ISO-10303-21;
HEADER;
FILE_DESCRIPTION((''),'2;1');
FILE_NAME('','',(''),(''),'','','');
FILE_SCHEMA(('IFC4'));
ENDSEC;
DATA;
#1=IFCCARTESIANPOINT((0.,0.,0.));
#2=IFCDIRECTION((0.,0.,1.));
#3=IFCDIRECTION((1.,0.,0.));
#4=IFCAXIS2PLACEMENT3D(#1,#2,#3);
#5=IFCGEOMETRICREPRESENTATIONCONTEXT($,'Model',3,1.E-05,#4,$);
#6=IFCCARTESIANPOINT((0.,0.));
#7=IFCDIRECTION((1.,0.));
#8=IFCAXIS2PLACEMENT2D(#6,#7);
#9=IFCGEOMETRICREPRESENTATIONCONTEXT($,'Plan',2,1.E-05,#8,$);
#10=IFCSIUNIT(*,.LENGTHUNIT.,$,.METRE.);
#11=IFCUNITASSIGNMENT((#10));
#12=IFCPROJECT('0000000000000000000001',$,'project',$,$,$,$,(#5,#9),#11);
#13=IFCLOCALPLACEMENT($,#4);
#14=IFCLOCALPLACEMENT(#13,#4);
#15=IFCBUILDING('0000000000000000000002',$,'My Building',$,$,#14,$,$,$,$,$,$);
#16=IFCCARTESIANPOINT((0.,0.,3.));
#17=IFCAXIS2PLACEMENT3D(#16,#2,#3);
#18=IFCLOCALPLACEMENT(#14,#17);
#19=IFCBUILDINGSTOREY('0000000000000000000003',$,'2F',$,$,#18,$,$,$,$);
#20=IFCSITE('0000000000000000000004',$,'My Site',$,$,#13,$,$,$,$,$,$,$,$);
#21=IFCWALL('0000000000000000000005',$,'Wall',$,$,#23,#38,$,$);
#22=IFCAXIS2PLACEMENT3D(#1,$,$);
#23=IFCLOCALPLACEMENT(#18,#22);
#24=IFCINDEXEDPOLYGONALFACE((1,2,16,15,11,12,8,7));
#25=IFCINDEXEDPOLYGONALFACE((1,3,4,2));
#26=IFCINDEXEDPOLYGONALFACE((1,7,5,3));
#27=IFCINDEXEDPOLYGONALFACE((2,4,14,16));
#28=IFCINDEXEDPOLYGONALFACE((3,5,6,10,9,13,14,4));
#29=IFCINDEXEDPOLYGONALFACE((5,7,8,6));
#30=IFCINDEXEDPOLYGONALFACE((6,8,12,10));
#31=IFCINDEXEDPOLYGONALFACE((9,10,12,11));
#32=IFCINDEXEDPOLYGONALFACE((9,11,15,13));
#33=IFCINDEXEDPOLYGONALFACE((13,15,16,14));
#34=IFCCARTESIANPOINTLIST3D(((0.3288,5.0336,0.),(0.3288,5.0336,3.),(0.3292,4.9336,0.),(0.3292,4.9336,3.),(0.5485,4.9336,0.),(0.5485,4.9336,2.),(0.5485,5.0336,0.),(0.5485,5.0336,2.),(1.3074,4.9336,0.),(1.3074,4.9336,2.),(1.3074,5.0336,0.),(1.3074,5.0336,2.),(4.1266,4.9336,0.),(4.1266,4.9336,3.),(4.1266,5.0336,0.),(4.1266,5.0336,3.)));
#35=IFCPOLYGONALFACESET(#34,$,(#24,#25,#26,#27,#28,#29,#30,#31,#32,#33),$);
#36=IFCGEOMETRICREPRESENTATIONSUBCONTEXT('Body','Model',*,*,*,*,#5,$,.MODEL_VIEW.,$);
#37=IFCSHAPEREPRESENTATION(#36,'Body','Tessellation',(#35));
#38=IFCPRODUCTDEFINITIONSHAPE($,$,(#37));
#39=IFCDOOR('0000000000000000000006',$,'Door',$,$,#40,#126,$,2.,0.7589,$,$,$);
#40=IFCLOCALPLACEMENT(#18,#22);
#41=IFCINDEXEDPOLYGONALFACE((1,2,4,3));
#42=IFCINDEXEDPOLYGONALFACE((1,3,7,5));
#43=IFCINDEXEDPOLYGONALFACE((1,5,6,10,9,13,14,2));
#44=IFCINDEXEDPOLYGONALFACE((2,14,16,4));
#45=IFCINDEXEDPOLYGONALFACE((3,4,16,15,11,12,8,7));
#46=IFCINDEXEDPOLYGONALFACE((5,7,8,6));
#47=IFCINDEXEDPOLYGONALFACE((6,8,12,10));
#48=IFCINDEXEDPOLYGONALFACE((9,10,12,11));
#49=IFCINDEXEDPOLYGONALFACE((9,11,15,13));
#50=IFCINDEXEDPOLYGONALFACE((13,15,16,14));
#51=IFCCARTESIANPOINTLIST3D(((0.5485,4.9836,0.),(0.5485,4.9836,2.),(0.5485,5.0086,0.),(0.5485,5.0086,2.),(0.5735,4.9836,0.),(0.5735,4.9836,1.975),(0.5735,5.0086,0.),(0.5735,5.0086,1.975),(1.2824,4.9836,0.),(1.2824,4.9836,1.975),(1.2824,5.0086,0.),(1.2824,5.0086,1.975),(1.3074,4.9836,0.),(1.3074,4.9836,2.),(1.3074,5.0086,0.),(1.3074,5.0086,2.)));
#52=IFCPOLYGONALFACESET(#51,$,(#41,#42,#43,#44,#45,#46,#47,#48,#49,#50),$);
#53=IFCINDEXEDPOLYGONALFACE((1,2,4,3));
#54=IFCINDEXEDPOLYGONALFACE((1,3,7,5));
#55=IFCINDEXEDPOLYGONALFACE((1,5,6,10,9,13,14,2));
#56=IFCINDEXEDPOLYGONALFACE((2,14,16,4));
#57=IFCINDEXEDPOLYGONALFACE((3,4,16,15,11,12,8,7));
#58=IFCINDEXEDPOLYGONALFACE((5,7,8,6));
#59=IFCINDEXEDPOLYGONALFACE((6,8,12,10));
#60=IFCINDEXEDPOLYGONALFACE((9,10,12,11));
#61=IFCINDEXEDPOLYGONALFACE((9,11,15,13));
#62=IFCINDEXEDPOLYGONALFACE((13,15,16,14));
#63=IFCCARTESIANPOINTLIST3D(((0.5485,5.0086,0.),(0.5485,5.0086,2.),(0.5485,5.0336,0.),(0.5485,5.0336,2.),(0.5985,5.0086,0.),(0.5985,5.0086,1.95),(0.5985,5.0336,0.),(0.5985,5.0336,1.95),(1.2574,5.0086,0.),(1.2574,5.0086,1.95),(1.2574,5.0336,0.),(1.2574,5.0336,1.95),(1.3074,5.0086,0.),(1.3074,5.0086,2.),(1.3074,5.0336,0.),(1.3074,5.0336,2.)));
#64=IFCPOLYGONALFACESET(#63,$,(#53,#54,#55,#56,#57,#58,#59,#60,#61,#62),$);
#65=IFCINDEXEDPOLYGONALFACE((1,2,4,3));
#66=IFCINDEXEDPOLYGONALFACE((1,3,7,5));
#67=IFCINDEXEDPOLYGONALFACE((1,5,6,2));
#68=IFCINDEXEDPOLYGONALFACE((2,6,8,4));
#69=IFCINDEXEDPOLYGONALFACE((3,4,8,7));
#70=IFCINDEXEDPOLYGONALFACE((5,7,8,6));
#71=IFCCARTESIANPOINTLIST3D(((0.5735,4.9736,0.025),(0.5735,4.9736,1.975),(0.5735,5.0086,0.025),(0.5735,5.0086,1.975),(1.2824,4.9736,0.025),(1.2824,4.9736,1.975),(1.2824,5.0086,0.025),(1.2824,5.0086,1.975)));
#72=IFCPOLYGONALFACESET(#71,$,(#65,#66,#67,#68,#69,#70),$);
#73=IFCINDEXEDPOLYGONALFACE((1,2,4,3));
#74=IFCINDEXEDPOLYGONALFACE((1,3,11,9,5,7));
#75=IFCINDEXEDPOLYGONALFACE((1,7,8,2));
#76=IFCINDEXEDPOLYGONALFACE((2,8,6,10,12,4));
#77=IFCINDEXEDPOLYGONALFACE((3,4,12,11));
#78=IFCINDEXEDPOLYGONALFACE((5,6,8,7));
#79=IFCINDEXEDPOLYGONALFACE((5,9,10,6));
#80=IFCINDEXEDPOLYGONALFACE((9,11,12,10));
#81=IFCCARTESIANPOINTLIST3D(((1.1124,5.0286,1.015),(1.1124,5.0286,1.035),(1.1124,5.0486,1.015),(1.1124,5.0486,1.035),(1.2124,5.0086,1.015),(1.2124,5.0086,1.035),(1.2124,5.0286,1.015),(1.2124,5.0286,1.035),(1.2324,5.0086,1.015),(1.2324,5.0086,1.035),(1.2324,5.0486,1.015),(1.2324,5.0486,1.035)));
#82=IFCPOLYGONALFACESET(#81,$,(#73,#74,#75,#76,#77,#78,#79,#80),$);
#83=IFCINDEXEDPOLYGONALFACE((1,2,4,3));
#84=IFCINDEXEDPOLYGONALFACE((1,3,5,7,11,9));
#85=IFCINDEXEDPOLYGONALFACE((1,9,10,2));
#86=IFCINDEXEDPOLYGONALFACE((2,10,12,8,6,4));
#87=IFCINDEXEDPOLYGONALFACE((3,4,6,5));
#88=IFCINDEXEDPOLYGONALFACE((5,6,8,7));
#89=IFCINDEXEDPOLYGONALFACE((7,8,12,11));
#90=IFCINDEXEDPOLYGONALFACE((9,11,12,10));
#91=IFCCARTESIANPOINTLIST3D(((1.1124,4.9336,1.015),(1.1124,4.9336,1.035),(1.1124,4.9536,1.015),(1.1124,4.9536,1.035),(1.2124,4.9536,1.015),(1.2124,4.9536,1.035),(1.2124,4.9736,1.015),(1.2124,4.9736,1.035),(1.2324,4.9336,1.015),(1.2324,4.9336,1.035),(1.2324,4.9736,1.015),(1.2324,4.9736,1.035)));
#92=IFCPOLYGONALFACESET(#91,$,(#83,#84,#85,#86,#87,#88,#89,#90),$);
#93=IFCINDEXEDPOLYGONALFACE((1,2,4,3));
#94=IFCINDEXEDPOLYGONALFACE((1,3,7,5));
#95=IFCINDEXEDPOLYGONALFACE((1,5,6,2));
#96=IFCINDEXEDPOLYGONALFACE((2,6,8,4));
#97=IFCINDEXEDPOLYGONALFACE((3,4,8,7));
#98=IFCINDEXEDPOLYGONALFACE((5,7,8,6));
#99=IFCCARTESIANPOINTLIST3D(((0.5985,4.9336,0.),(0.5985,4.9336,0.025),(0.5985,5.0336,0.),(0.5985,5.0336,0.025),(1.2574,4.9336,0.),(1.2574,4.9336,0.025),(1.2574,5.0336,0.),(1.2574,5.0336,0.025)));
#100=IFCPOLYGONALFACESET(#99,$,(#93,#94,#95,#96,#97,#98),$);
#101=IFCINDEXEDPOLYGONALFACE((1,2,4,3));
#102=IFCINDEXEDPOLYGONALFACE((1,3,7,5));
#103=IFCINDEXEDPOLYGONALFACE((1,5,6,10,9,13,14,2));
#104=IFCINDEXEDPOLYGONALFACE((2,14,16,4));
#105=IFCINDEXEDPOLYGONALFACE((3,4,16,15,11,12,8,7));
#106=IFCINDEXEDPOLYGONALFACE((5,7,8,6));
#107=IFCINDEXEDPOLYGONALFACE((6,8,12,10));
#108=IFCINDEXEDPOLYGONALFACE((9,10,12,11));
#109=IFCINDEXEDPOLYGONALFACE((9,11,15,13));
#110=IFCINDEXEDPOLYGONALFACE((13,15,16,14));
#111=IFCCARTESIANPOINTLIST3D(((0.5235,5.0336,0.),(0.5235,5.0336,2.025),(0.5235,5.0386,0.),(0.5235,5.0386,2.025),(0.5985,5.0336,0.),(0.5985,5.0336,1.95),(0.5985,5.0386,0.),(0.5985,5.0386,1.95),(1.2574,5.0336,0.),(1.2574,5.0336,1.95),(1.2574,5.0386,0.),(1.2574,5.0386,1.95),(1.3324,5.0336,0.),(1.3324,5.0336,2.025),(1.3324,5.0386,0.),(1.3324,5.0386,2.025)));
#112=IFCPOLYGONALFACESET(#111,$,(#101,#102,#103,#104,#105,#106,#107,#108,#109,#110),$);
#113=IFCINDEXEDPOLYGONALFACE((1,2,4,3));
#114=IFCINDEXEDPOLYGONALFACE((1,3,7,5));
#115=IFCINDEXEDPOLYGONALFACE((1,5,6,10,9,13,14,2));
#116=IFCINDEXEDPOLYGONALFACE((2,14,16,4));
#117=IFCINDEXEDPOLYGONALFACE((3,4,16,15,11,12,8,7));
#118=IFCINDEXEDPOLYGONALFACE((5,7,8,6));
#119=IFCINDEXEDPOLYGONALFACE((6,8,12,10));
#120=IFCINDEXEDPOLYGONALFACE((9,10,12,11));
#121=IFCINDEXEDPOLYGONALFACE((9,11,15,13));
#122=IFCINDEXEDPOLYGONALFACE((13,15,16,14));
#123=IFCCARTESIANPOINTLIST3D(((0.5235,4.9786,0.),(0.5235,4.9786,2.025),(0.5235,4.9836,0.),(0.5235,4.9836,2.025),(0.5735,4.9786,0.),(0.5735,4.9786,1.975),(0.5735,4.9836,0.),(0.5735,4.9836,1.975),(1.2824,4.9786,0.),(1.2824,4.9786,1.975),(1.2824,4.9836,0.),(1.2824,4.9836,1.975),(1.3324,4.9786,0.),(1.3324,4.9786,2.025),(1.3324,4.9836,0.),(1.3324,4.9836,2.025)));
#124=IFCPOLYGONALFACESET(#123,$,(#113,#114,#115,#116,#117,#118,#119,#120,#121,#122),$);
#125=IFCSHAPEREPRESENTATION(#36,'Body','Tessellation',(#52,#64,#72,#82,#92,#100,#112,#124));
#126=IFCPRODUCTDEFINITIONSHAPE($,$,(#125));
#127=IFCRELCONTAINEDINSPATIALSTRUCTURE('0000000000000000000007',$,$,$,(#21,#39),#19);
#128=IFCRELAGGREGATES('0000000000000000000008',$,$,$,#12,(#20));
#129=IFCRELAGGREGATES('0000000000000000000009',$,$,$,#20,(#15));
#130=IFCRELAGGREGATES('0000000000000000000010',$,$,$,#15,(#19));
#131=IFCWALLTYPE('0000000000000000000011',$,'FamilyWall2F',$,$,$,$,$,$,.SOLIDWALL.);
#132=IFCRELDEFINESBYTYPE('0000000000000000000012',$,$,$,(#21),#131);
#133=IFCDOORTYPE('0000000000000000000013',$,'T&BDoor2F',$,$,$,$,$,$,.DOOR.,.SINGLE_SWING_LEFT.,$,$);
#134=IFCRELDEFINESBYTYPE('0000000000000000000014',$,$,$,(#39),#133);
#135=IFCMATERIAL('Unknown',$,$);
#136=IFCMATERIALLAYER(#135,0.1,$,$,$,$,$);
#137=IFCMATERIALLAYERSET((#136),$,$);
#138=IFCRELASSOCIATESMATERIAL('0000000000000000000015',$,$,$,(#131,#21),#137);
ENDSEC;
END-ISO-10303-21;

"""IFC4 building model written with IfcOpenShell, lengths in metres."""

from ifc_helpers import new_model, entity, si_unit, frame, origin_with_axes, origin_2d_with_axis, place, context, subcontext, project, spatial, line, indexed_curve, outline, extrude, shape, source, transform, mapped, material, layer, layer_set, layer_usage, type_object, type_shapes, element, fill, save


model = new_model("IFC4")

# Units and contexts
model_context = context("Model", 3, precision=1e-05, world=origin_with_axes())
plan_context = context("Plan", 2, precision=1e-05, world=origin_2d_with_axis())
body_context_1 = subcontext(model_context, "Body", "Model", "MODEL_VIEW")
body_context_2 = subcontext(plan_context, "Body", "Plan", "PLAN_VIEW")
ifc_project = project(units=[si_unit("LENGTHUNIT", "METRE")], contexts=[model_context, plan_context])

# Site, building, storey
site_placement = place(None, origin_with_axes())
site = spatial("IfcSite", under=ifc_project, at=site_placement, Name="My Site")
building_placement = place(site_placement, origin_with_axes())
building = spatial("IfcBuilding", under=site, at=building_placement, Name="My Building")
storey_placement = place(building_placement, frame((0.0, 0.0, 3.0), z_axis=(0.0, 0.0, 1.0), x_axis=(1.0, 0.0, 0.0)))
storey = spatial("IfcBuildingStorey", under=building, at=storey_placement, Name="2F")

# Shared definitions
ifc_material = material(Name="Unknown")

# Wall, opening, door
ifc_layer_1 = layer(ifc_material, 0.1)
ifc_layer_set_1 = layer_set([ifc_layer_1])
ifc_layer_usage_1 = layer_usage(ifc_layer_set_1, "AXIS2", "POSITIVE", 0.0)
wall_type_1 = type_object("IfcWallType", Name="FamilyWall2F", PredefinedType="SOLIDWALL", material=ifc_layer_set_1)
wall_1_placement = place(storey_placement, frame((4.2266, 5.0336, 0.0), z_axis=(0.0, 0.0, 1.0), x_axis=(-1.0, 0.0, 0.0)))
wall_1 = element("IfcWall", 1, at=wall_1_placement, inside=storey, type_object=wall_type_1, material=ifc_layer_usage_1, Name="Wall", context=body_context_1, shape_type="SweptSolid", body=[
    extrude(outline(indexed_curve([(0.1, 0.0), (0.1, 0.1), (3.8974, 0.1), (3.8978, 0.0)], segments=[line(1, 2, 3, 4, 1)])), origin_with_axes(), (0.0, 0.0, 1.0), 3.0),
])
shared_shape_1 = source(origin_with_axes(), body_context_1, "Body", "SweptSolid", [
    extrude(outline(indexed_curve([(0.0, 0.0), (0.7589, 0.0), (0.7589, 2.0), (0.0, 2.0)], segments=[line(1, 2, 3, 4, 1)])), frame((0.0, -0.6, 0.0), z_axis=(0.0, -1.0, 0.0), x_axis=(1.0, 0.0, 0.0)), (0.0, 0.0, -1.0), 1.2),
])
opening_1_placement = place(wall_1_placement, frame((2.9192, 0.0, 0.0), z_axis=(0.0, 0.0, 1.0), x_axis=(1.0, 0.0, 0.0)))
opening_1 = element("IfcOpeningElement", 2, at=opening_1_placement, cuts=wall_1, PredefinedType="OPENING", context=body_context_1, shape_type="MappedRepresentation", body=[
    mapped(shared_shape_1, transform((0.0, 0.0, 0.0), x_axis=(1.0, 0.0, 0.0), y_axis=(0.0, 1.0, 0.0), z_axis=(0.0, 0.0, 1.0), scale=1.0)),
])
door_type_1 = type_object("IfcDoorType", Name="T&BDoor2F", OperationType="SINGLE_SWING_LEFT", PredefinedType="DOOR")
shared_shape_2 = source(origin_with_axes(), body_context_1, "Body", "SweptSolid", [
    extrude(outline(indexed_curve([(0.0, 0.0), (0.0, 2.0), (0.7589, 2.0), (0.7589, 0.0), (0.7339, 0.0), (0.7339, 1.975), (0.025, 1.975), (0.025, 0.0)], segments=[line(1, 2, 3, 4, 5, 6, 7, 8, 1)])), frame((0.0, 0.025, 0.0), z_axis=(0.0, -1.0, 0.0), x_axis=(1.0, 0.0, 0.0)), (0.0, 0.0, -1.0), 0.025),
    extrude(outline(indexed_curve([(0.0, 0.0), (0.0, 2.0), (0.7589, 2.0), (0.7589, 0.0), (0.7089, 0.0), (0.7089, 1.95), (0.05, 1.95), (0.05, 0.0)], segments=[line(1, 2, 3, 4, 5, 6, 7, 8, 1)])), frame((0.0, 0.0, 0.0), z_axis=(0.0, -1.0, 0.0), x_axis=(1.0, 0.0, 0.0)), (0.0, 0.0, -1.0), 0.025),
    extrude(outline(indexed_curve([(0.0, 0.0), (0.7089, 0.0), (0.7089, 0.035), (0.0, 0.035)], segments=[line(1, 2, 3, 4, 1)])), frame((0.025, 0.025, 0.025), z_axis=(0.0, 0.0, 1.0), x_axis=(1.0, 0.0, 0.0)), (0.0, 0.0, 1.0), 1.95),
    extrude(outline(indexed_curve([(0.0, 0.0), (0.0, -0.04), (0.12, -0.04), (0.12, -0.02), (0.02, -0.02), (0.02, 0.0)], segments=[line(1, 2, 3, 4, 5, 6, 1)])), frame((0.075, 0.025, 1.015), z_axis=(0.0, 0.0, 1.0), x_axis=(1.0, 0.0, 0.0)), (0.0, 0.0, 1.0), 0.02),
    extrude(outline(indexed_curve([(0.0, 0.0), (0.0, 0.04), (0.12, 0.04), (0.12, 0.02), (0.02, 0.02), (0.02, 0.0)], segments=[line(1, 2, 3, 4, 5, 6, 1)])), frame((0.075, 0.06, 1.015), z_axis=(0.0, 0.0, 1.0), x_axis=(1.0, 0.0, 0.0)), (0.0, 0.0, 1.0), 0.02),
    extrude(outline(indexed_curve([(0.0, 0.0), (0.6589, 0.0), (0.6589, 0.1), (0.0, 0.1)], segments=[line(1, 2, 3, 4, 1)])), frame((0.05, 0.0, 0.0), z_axis=(0.0, 0.0, 1.0), x_axis=(1.0, 0.0, 0.0)), (0.0, 0.0, 1.0), 0.025),
    extrude(outline(indexed_curve([(0.0, 0.0), (0.0, 2.025), (0.8089, 2.025), (0.8089, 0.0), (0.7339, 0.0), (0.7339, 1.95), (0.075, 1.95), (0.075, 0.0)], segments=[line(1, 2, 3, 4, 5, 6, 7, 8, 1)])), frame((-0.025, -0.005, 0.0), z_axis=(0.0, -1.0, 0.0), x_axis=(1.0, 0.0, 0.0)), (0.0, 0.0, -1.0), 0.005),
    extrude(outline(indexed_curve([(0.0, 0.0), (0.0, 2.025), (0.8089, 2.025), (0.8089, 0.0), (0.7589, 0.0), (0.7589, 1.975), (0.05, 1.975), (0.05, 0.0)], segments=[line(1, 2, 3, 4, 5, 6, 7, 8, 1)])), frame((-0.025, 0.05, 0.0), z_axis=(0.0, -1.0, 0.0), x_axis=(1.0, 0.0, 0.0)), (0.0, 0.0, -1.0), 0.005),
])
shared_shape_3 = source(origin_with_axes(), body_context_2, "Body", "Curve2D", [
    entity("IfcIndexedPolyCurve", entity("IfcCartesianPointList2D", [[0.0, 0.0], [0.0, 0.05], [0.025, 0.05], [0.025, 0.025], [0.05, 0.025], [0.05, 0.0]]), [entity("IfcLineIndex", [1, 2, 3, 4, 5, 6, 1])]),
    entity("IfcIndexedPolyCurve", entity("IfcCartesianPointList2D", [[0.7589, 0.0], [0.7589, 0.05], [0.7339, 0.05], [0.7339, 0.025], [0.7089, 0.025], [0.7089, 0.0]]), [entity("IfcLineIndex", [1, 2, 3, 4, 5, 6, 1])]),
    entity("IfcTrimmedCurve", entity("IfcEllipse", entity("IfcAxis2Placement2D", entity("IfcCartesianPoint", [0.6989, 0.05]), entity("IfcDirection", [1.0, 0.0])), 0.6739, 0.7089), [entity("IfcCartesianPoint", [0.6989, 0.7589])], [entity("IfcCartesianPoint", [0.025, 0.05])], True, "CARTESIAN"),
    entity("IfcIndexedPolyCurve", entity("IfcCartesianPointList2D", [[0.7339, 0.05], [0.6989, 0.05], [0.6989, 0.7589], [0.7339, 0.7589]]), [entity("IfcLineIndex", [1, 2, 3, 4, 1])]),
])
type_shapes(door_type_1, [shared_shape_2, shared_shape_3])
door_1_placement = place(opening_1_placement, frame((0.0, 0.0, 0.0), z_axis=(0.0, 0.0, 1.0), x_axis=(1.0, 0.0, 0.0)))
door_1 = element("IfcDoor", 3, at=door_1_placement, inside=storey, type_object=door_type_1, Name="Door", OverallHeight=2.0, OverallWidth=0.7589, shapes=[
    shape(body_context_1, "Body", "MappedRepresentation", [mapped(shared_shape_2, transform((0.0, 0.0, 0.0), x_axis=(1.0, 0.0, 0.0), y_axis=(0.0, 1.0, 0.0), z_axis=(0.0, 0.0, 1.0), scale=1.0))]),
    shape(body_context_2, "Body", "MappedRepresentation", [mapped(shared_shape_3, transform((0.0, 0.0, 0.0), x_axis=(1.0, 0.0, 0.0), y_axis=(0.0, 1.0, 0.0), z_axis=(0.0, 0.0, 1.0), scale=1.0))]),
])
fill(opening_1, door_1)

save(model, "model.ifc")
